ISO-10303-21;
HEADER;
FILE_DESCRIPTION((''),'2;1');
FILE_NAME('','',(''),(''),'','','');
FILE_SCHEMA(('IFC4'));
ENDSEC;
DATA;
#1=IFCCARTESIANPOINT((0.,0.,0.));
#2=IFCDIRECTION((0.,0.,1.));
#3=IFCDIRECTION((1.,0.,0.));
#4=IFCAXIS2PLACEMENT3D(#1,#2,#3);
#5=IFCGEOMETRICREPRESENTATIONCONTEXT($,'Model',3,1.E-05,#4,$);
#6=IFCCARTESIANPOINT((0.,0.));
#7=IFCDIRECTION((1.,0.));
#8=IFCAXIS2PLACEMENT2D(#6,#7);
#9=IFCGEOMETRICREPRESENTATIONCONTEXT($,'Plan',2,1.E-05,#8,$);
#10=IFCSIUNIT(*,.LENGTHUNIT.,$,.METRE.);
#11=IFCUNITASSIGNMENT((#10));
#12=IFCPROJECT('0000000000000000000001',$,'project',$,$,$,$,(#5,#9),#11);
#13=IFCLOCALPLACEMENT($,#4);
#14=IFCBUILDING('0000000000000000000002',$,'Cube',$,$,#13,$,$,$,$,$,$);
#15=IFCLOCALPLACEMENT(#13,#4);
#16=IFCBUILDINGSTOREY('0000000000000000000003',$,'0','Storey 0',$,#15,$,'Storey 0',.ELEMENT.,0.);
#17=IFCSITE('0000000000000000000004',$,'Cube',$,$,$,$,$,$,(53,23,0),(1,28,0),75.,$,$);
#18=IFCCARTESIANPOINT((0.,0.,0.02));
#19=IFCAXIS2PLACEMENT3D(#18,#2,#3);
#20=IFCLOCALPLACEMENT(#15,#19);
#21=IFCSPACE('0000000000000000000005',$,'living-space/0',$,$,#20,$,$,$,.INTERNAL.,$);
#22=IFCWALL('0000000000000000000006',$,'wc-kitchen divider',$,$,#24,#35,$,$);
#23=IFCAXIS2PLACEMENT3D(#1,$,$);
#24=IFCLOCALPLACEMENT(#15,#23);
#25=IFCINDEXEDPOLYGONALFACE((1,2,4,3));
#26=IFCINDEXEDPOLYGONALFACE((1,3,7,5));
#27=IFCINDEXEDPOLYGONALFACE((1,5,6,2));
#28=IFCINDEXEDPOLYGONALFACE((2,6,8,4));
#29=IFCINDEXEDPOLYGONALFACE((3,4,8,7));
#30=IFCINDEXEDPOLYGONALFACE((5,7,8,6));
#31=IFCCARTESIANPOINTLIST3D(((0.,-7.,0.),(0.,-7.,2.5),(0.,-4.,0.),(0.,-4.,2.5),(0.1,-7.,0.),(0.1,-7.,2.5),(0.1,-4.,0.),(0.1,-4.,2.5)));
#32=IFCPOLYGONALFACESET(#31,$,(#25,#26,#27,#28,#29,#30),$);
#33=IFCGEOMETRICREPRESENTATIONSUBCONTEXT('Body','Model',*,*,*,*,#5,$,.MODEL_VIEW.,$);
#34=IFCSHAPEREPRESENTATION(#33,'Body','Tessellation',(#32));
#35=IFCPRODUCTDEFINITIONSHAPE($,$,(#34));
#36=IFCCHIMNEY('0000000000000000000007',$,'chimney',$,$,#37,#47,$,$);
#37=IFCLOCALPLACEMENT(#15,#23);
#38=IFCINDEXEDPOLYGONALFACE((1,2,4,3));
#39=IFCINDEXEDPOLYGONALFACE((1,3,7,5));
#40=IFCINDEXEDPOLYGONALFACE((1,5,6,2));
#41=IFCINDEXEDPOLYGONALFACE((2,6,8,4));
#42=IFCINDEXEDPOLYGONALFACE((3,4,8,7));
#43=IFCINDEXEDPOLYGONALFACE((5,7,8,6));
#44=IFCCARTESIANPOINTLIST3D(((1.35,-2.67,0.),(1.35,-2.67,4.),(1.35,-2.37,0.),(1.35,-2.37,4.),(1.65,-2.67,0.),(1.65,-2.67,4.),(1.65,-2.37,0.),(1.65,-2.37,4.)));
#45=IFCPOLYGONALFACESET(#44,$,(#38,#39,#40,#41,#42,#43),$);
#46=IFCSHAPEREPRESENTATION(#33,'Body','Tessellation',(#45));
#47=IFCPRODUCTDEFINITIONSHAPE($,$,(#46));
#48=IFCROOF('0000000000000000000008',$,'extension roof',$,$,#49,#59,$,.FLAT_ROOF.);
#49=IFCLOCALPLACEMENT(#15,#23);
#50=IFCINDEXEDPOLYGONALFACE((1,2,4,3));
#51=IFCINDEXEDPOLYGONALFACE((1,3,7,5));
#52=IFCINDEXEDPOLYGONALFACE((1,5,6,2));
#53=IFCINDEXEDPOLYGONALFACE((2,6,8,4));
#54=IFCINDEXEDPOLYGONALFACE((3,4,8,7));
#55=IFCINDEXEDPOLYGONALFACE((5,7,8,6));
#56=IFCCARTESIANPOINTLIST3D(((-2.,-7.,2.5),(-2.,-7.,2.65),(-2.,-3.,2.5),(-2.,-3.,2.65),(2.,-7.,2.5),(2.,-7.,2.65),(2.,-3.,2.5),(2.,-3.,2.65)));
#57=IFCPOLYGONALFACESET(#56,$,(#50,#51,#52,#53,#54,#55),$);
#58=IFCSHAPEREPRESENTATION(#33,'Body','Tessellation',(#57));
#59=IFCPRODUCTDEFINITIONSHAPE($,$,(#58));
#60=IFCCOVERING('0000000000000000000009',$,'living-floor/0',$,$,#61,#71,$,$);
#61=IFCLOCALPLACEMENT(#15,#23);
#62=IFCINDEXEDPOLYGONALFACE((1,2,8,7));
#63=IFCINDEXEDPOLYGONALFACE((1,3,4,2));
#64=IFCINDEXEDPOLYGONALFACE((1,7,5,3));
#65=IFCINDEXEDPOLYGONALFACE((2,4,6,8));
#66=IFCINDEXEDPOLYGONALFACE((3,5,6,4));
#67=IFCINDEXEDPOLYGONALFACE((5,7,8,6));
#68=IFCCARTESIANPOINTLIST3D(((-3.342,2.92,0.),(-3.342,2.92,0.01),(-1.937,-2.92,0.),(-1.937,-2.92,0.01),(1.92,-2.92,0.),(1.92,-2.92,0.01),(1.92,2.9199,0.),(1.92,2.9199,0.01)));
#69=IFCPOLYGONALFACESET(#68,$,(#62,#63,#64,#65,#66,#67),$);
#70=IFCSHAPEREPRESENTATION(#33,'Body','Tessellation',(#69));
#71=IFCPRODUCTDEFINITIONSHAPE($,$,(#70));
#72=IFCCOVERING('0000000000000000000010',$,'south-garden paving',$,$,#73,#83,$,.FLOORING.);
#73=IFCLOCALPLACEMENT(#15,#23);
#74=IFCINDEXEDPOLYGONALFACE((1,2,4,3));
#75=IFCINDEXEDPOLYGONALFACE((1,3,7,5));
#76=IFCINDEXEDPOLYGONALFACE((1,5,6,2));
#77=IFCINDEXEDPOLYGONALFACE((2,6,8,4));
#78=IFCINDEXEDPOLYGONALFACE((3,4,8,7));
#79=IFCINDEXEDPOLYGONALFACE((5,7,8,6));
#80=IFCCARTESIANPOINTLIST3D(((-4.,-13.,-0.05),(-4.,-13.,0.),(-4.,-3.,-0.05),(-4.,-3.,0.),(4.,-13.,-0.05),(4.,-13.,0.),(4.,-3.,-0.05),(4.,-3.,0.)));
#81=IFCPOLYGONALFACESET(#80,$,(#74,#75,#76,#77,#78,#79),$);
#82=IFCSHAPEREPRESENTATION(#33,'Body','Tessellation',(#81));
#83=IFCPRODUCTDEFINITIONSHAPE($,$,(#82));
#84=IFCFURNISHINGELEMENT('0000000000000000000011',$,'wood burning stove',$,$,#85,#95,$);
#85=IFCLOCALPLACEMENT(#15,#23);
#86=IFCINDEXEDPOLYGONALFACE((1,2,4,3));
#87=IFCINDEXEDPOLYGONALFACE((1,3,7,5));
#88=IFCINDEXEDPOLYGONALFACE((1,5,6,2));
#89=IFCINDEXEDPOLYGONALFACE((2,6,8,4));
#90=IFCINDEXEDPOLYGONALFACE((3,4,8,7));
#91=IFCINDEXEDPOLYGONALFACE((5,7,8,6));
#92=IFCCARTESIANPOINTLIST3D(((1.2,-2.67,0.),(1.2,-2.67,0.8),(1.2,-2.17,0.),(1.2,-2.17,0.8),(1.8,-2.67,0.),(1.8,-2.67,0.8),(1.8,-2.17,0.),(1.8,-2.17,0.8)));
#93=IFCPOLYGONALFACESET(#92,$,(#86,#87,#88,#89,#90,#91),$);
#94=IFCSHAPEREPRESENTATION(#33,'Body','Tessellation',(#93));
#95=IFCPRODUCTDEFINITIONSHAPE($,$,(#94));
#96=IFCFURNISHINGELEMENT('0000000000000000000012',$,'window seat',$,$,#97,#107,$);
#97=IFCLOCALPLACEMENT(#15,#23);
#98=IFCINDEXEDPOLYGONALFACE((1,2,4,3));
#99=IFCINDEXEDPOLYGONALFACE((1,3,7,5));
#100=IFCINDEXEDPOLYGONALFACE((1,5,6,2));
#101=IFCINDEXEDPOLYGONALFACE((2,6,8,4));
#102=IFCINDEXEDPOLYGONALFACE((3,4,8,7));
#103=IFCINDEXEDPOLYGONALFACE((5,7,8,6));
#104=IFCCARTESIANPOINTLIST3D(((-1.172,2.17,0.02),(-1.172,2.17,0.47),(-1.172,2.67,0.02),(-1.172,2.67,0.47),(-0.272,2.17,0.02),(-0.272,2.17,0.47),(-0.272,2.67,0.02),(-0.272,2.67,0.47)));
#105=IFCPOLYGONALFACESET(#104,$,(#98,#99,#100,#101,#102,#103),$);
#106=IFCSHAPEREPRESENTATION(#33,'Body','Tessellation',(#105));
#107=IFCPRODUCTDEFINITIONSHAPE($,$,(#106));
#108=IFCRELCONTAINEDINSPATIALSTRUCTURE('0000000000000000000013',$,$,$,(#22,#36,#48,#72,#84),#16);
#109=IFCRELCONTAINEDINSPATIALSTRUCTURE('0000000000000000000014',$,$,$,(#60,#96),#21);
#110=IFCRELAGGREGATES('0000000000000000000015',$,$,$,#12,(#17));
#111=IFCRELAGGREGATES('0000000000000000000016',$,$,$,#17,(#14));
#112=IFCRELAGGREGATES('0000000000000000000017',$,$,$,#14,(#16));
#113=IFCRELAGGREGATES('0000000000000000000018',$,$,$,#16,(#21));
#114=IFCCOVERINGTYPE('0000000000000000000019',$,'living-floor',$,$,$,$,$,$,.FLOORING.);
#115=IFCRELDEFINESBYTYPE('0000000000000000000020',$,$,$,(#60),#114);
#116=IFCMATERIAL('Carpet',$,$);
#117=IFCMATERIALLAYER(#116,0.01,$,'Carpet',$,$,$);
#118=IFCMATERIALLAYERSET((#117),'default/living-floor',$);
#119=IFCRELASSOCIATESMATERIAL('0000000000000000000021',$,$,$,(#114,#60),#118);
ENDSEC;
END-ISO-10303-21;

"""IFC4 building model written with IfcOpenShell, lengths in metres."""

from ifc_helpers import new_model, si_unit, frame, origin_with_axes, origin_2d_with_axis, place, context, subcontext, project, spatial, polyline, indexed_curve, outline, extrude, material, layer, layer_set, layer_usage, type_object, element, save


model = new_model("IFC4")

# Units and contexts
model_context = context("Model", 3, precision=1e-05, world=origin_with_axes())
plan_context = context("Plan", 2, precision=1e-05, world=origin_2d_with_axis())
body_context = subcontext(model_context, "Body", "Model", "MODEL_VIEW")
ifc_project = project(units=[si_unit("LENGTHUNIT", "METRE")], contexts=[model_context, plan_context])

# Site, building, storey
site = spatial("IfcSite", under=ifc_project, Name="Cube", RefLatitude=(53, 23, 0), RefLongitude=(1, 28, 0), RefElevation=75.0)
building_placement = place(None, origin_with_axes())
building = spatial("IfcBuilding", under=site, at=building_placement, Name="Cube")
storey_placement = place(building_placement, origin_with_axes())
storey = spatial("IfcBuildingStorey", under=building, at=storey_placement, Name="0", Description="Storey 0", LongName="Storey 0", CompositionType="ELEMENT", Elevation=0.0)

# Wall
wall_1_placement = place(storey_placement, frame((0.0, -4.0, 0.0), z_axis=(0.0, 0.0, 1.0), x_axis=(0.0, -1.0, 0.0)))
element("IfcWall", 1, at=wall_1_placement, inside=storey, Name="wc-kitchen divider", context=body_context, shape_type="SweptSolid", body=[
    extrude(outline(indexed_curve([(0.0, 0.0), (0.0, 0.1), (3.0, 0.1), (3.0, 0.0), (0.0, 0.0)], self_intersect=False)), origin_with_axes(), (0.0, 0.0, 1.0), 2.5),
])

# Chimney
chimney_placement = place(storey_placement, frame((1.35, -2.67, 0.0), z_axis=(0.0, 0.0, 1.0), x_axis=(1.0, 0.0, 0.0)))
element("IfcChimney", 2, at=chimney_placement, inside=storey, Name="chimney", context=body_context, shape_type="SweptSolid", body=[
    extrude(outline(indexed_curve([(0.0, 0.0), (0.3, 0.0), (0.3, 0.3), (0.0, 0.3)])), None, (0.0, 0.0, 1.0), 4.0),
])

# Roof
roof_placement = place(storey_placement, frame((-2.0, -7.0, 2.5), z_axis=(0.0, 0.0, 1.0), x_axis=(1.0, 0.0, 0.0)))
element("IfcRoof", 3, at=roof_placement, inside=storey, Name="extension roof", PredefinedType="FLAT_ROOF", context=body_context, shape_type="SweptSolid", body=[
    extrude(outline(indexed_curve([(0.0, 0.0), (4.0, 0.0), (4.0, 4.0), (0.0, 4.0)])), None, (0.0, 0.0, 1.0), 0.15),
])

# Shared definitions
space_placement = place(storey_placement, frame((0.0, 0.0, 0.02), z_axis=(0.0, 0.0, 1.0), x_axis=(1.0, 0.0, 0.0)))
space = spatial("IfcSpace", under=storey, at=space_placement, Name="living-space/0", PredefinedType="INTERNAL")

# Coverings
ifc_material_1 = material(Name="Carpet")
ifc_layer_1 = layer(ifc_material_1, 0.01, Name="Carpet")
ifc_layer_set_1 = layer_set([ifc_layer_1], Name="default/living-floor")
ifc_layer_usage_1 = layer_usage(ifc_layer_set_1, "AXIS3", "POSITIVE", 0.0)
covering_type = type_object("IfcCoveringType", Name="living-floor", PredefinedType="FLOORING", material=ifc_layer_set_1)
covering_1_placement = place(space_placement, frame((0.0, 0.0, -0.02), z_axis=(0.0, 0.0, 1.0), x_axis=(1.0, 0.0, 0.0)))
element("IfcCovering", 4, at=covering_1_placement, inside=space, type_object=covering_type, material=ifc_layer_usage_1, Name="living-floor/0", context=body_context, shape_type="SweptSolid", body=[
    extrude(outline(polyline([(1.92, 2.9199), (-3.342, 2.92), (-1.937, -2.92), (1.92, -2.92), (1.92, 2.9199)])), origin_with_axes(), (0.0, 0.0, 1.0), 0.01),
])
covering_2_placement = place(storey_placement, frame((-4.0, -13.0, 0.0), z_axis=(0.0, 0.0, 1.0), x_axis=(1.0, 0.0, 0.0)))
element("IfcCovering", 5, at=covering_2_placement, inside=storey, Name="south-garden paving", PredefinedType="FLOORING", context=body_context, shape_type="SweptSolid", body=[
    extrude(outline(indexed_curve([(0.0, 0.0), (8.0, 0.0), (8.0, 10.0), (0.0, 10.0)])), None, (0.0, 0.0, -1.0), 0.05),
])

# Furnishing elements
furnishing_1_placement = place(storey_placement, frame((1.2, -2.67, 0.0), z_axis=(0.0, 0.0, 1.0), x_axis=(1.0, 0.0, 0.0)))
element("IfcFurnishingElement", 6, at=furnishing_1_placement, inside=storey, Name="wood burning stove", context=body_context, shape_type="SweptSolid", body=[
    extrude(outline(indexed_curve([(0.0, 0.0), (0.6, 0.0), (0.6, 0.5), (0.0, 0.5)])), None, (0.0, 0.0, 1.0), 0.8),
])
furnishing_2_placement = place(space_placement, frame((-1.172, 2.17, 0.0), z_axis=(0.0, 0.0, 1.0), x_axis=(1.0, 0.0, 0.0)))
element("IfcFurnishingElement", 7, at=furnishing_2_placement, inside=space, Name="window seat", context=body_context, shape_type="SweptSolid", body=[
    extrude(outline(indexed_curve([(0.0, 0.0), (0.9, 0.0), (0.9, 0.5), (0.0, 0.5)])), None, (0.0, 0.0, 1.0), 0.45),
])

save(model, "model.ifc")
